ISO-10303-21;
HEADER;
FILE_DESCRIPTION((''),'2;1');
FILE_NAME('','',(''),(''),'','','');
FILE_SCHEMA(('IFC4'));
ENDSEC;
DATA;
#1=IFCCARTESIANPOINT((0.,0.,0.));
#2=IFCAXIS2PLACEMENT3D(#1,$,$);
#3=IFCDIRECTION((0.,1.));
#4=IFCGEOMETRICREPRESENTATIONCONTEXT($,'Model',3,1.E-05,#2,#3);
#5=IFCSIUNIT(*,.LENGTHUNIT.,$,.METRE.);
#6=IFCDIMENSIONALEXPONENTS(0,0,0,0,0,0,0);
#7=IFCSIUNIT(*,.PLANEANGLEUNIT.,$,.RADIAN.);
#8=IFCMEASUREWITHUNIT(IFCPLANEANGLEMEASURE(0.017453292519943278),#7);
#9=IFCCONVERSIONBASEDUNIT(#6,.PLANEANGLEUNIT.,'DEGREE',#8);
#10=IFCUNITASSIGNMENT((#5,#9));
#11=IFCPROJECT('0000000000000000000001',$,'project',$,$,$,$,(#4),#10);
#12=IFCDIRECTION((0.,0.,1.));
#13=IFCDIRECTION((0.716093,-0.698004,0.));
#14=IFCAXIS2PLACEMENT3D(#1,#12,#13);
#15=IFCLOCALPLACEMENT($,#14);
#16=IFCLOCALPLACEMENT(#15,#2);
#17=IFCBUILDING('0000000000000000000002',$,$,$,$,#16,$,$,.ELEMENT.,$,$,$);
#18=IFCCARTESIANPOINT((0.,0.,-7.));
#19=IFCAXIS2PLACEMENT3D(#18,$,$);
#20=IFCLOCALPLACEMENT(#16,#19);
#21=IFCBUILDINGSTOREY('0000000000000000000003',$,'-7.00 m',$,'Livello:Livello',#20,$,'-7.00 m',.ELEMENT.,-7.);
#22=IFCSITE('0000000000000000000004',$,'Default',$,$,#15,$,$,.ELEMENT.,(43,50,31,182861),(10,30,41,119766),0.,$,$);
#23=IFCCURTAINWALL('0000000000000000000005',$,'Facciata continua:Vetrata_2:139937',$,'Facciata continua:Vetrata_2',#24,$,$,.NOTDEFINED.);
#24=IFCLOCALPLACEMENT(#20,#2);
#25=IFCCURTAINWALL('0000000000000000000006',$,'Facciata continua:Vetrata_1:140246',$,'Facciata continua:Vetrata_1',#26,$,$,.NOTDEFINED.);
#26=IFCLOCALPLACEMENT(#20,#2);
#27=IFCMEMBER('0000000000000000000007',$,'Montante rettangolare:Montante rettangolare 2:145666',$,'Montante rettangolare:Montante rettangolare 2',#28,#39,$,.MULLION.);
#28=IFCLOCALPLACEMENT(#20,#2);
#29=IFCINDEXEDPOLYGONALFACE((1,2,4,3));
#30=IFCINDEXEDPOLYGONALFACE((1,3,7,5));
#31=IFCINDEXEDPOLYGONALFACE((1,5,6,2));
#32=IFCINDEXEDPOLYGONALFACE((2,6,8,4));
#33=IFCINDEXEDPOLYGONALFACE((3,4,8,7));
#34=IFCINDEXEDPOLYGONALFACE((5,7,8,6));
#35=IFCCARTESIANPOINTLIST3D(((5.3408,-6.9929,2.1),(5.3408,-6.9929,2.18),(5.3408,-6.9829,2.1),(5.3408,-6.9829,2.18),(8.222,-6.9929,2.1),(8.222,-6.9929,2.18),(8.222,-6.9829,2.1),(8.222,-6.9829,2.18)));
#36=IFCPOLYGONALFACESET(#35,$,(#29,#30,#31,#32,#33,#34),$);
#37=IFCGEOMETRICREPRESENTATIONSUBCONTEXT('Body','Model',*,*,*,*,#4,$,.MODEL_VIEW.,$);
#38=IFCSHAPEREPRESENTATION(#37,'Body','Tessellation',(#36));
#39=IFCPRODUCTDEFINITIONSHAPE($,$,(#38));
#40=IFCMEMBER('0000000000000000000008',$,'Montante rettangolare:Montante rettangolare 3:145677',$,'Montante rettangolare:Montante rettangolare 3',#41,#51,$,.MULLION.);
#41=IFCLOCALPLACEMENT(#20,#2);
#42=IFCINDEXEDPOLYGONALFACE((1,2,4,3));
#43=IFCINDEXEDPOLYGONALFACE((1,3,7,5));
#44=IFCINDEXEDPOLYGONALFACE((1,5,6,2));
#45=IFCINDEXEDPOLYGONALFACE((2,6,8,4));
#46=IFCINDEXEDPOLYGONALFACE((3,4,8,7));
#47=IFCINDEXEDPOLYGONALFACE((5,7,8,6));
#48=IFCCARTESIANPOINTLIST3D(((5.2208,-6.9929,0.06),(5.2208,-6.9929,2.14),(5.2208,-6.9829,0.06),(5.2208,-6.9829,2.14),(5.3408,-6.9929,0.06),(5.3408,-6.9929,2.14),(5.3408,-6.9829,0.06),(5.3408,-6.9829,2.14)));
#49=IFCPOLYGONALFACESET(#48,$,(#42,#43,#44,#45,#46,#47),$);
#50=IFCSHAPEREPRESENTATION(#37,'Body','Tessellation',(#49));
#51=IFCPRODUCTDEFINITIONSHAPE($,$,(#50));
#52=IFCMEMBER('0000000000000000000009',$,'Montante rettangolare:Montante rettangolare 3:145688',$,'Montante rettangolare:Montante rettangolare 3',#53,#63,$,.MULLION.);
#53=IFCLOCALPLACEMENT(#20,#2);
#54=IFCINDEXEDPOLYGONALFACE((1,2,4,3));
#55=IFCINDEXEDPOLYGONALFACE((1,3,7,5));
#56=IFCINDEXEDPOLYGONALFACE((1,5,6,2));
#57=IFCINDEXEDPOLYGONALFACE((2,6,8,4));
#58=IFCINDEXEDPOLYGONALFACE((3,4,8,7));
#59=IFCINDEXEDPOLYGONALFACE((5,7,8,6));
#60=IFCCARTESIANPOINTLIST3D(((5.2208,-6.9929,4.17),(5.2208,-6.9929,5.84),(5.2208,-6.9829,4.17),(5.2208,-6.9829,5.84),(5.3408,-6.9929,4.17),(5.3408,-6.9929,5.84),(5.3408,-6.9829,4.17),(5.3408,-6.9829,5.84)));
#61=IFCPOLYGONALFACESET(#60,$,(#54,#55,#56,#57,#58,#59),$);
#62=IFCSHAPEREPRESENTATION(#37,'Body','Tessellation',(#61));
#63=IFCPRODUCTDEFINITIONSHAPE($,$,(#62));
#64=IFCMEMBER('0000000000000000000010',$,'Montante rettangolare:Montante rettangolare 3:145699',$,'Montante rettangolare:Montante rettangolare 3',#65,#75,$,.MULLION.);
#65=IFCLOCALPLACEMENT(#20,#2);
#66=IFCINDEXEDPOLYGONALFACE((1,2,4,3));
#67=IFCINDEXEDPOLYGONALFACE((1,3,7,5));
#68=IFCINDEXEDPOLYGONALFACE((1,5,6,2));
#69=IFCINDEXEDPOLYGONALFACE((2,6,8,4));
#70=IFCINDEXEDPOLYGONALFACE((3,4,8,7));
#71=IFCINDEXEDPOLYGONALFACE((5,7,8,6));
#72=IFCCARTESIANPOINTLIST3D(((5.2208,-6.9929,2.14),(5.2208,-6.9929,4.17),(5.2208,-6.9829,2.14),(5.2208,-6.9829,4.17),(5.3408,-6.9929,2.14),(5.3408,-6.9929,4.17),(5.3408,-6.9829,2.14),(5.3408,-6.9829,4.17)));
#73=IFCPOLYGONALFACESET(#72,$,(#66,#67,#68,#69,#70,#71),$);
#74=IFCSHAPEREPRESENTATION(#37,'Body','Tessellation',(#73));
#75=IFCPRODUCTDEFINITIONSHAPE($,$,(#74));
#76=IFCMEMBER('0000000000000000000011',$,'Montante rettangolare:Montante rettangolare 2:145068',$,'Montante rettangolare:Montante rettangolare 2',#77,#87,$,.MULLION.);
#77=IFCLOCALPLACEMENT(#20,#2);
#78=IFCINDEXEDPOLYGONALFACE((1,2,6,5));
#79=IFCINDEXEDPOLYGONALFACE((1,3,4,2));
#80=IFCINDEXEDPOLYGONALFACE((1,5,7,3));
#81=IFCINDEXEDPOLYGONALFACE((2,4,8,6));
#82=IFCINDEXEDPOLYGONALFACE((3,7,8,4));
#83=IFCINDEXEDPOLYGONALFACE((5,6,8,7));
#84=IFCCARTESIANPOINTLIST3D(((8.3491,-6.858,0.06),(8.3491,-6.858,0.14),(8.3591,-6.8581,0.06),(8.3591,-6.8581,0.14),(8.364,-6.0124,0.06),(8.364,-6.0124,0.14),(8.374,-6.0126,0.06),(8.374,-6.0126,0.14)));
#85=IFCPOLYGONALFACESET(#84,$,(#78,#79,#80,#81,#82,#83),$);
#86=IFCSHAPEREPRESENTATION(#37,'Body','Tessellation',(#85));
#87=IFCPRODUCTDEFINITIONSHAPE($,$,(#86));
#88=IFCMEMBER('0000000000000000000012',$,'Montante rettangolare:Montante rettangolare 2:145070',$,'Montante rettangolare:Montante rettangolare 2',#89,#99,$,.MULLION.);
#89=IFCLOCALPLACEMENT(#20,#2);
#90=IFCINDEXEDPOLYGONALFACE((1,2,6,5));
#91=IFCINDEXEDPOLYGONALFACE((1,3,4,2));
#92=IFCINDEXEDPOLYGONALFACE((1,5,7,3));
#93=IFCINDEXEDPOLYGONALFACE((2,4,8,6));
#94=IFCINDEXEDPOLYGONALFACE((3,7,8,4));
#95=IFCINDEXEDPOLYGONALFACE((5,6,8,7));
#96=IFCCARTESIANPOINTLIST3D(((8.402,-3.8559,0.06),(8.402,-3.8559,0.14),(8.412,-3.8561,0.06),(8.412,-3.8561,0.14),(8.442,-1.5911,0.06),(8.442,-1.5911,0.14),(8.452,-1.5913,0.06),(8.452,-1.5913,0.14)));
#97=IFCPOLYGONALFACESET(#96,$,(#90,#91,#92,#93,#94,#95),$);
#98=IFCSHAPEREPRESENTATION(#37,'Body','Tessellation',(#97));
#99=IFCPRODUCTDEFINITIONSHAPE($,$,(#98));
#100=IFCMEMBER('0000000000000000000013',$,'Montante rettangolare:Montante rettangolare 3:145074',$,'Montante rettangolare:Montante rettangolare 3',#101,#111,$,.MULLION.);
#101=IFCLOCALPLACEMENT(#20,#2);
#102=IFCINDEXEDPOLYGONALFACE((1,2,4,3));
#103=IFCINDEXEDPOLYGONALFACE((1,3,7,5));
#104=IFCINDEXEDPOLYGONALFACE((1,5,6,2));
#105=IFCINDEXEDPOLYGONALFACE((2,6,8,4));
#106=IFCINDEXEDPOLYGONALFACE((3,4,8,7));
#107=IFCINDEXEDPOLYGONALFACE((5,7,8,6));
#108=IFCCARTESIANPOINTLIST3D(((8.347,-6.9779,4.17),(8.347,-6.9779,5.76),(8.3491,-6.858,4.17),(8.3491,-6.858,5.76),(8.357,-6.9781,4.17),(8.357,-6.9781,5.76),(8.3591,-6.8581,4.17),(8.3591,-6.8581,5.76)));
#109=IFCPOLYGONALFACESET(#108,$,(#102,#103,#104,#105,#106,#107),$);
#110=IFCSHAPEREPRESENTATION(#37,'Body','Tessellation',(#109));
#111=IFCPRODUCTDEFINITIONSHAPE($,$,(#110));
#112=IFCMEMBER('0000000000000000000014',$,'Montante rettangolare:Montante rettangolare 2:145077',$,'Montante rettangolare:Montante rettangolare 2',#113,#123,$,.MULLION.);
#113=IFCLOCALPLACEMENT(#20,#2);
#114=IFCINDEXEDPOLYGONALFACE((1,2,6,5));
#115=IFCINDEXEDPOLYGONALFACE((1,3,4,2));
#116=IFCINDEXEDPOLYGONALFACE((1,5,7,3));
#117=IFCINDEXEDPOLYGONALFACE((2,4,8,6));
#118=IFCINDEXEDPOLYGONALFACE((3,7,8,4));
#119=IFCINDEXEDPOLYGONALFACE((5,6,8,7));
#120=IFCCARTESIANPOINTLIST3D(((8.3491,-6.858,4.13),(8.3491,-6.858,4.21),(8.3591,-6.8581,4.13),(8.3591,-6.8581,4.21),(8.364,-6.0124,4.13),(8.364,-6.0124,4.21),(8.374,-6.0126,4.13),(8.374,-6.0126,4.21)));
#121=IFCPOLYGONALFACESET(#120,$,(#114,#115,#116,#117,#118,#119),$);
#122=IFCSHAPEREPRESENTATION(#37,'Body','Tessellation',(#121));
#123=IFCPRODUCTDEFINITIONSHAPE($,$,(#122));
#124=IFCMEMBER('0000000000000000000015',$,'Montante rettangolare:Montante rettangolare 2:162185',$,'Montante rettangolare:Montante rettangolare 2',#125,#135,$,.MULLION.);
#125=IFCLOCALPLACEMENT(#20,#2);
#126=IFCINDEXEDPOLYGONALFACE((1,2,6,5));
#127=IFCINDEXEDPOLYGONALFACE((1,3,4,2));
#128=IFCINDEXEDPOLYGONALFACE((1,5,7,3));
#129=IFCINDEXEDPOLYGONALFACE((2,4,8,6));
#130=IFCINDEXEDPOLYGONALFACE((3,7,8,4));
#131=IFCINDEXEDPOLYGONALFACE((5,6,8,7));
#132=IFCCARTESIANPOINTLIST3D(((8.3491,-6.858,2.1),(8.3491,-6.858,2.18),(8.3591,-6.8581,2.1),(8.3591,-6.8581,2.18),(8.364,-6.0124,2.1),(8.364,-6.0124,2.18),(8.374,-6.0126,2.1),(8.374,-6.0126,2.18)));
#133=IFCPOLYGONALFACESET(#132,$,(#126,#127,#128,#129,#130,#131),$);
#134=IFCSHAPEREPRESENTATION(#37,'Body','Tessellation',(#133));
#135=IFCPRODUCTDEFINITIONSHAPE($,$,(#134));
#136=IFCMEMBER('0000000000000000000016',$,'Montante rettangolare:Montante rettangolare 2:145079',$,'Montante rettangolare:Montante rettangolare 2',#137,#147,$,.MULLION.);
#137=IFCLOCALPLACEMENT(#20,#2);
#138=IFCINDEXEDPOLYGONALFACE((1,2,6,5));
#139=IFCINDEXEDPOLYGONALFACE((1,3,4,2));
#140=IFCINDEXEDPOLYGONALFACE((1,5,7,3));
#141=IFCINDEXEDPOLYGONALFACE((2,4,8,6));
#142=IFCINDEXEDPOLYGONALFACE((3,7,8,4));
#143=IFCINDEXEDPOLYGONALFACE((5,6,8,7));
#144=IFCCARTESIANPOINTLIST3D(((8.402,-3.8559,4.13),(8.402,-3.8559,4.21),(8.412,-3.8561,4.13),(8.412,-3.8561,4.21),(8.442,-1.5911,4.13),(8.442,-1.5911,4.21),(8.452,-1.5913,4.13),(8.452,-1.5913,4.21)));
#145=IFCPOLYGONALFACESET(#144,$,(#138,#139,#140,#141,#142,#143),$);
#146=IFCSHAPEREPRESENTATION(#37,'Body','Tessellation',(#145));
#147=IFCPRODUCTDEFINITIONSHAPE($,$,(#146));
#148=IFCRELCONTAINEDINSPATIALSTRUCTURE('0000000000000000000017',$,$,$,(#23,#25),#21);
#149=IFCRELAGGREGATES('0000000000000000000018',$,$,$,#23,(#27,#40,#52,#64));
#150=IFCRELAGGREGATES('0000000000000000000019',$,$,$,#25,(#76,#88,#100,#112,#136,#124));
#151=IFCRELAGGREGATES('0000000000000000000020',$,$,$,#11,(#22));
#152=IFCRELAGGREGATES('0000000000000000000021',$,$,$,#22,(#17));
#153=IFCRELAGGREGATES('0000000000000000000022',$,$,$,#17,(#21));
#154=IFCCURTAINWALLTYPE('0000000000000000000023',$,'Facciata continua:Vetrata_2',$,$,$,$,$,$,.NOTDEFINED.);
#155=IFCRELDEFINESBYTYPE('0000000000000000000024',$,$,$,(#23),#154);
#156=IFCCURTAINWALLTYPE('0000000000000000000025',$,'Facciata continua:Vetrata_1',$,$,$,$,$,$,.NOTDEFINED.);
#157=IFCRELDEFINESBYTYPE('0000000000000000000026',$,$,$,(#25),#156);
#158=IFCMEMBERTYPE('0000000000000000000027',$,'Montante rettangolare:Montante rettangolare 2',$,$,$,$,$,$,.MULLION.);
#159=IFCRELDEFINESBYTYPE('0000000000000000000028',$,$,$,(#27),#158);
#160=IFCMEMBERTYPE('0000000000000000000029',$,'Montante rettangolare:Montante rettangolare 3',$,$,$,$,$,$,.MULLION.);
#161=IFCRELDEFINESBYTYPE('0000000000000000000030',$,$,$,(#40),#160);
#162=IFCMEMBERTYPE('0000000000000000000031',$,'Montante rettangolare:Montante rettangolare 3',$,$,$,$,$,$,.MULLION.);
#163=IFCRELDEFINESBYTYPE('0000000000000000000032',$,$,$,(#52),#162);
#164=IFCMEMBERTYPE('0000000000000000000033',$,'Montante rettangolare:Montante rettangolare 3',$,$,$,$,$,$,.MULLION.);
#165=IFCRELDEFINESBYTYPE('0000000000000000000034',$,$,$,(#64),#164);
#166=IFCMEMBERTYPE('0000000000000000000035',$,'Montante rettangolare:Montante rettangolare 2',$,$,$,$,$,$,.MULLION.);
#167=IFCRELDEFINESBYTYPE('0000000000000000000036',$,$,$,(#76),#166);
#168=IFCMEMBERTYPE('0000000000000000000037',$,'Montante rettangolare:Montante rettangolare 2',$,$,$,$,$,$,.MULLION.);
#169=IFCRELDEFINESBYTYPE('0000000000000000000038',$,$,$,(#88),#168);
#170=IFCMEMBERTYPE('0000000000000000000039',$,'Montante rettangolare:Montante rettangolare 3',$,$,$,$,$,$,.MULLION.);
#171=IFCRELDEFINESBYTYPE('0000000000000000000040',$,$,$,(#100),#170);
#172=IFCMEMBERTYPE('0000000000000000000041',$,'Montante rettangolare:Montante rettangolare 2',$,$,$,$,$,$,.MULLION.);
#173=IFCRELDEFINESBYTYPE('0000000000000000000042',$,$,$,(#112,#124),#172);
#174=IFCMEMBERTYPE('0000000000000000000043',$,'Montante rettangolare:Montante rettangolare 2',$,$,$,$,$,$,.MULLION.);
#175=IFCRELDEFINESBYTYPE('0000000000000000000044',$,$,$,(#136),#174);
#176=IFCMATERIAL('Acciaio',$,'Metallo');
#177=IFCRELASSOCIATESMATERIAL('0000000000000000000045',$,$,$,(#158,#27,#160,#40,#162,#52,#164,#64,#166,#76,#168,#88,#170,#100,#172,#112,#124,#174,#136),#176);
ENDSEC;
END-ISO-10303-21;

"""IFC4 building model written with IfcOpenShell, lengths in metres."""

from ifc_helpers import new_model, entity, si_unit, converted_unit, direction, frame, origin, place, context, subcontext, project, spatial, indexed_curve, outline, extrude, source, transform, mapped, material, type_object, type_shapes, element, aggregate, save


model = new_model("IFC4")

# Units and contexts
model_context = context("Model", 3, precision=1e-05, world=origin(), true_north=direction((0.0, 1.0)))
body_context = subcontext(model_context, "Body", "Model", "MODEL_VIEW")
ifc_project = project(units=[si_unit("LENGTHUNIT", "METRE"), converted_unit("PLANEANGLEUNIT", "DEGREE", entity("IfcPlaneAngleMeasure", 0.017453292519943278), si_unit("PLANEANGLEUNIT", "RADIAN"), dimensions=[0, 0, 0, 0, 0, 0, 0])], contexts=[model_context])

# Site, building, storey
site_placement = place(None, frame((0.0, 0.0, 0.0), z_axis=(0.0, 0.0, 1.0), x_axis=(0.716093, -0.698004, 0.0)))
site = spatial("IfcSite", under=ifc_project, at=site_placement, Name="Default", CompositionType="ELEMENT", RefLatitude=(43, 50, 31, 182861), RefLongitude=(10, 30, 41, 119766), RefElevation=0.0)
building_placement = place(site_placement, origin())
building = spatial("IfcBuilding", under=site, at=building_placement, CompositionType="ELEMENT")
storey_placement = place(building_placement, frame((0.0, 0.0, -7.0)))
storey = spatial("IfcBuildingStorey", under=building, at=storey_placement, Name="-7.00 m", ObjectType="Livello:Livello", LongName="-7.00 m", CompositionType="ELEMENT", Elevation=-7.0)

# Curtain wall
curtain_wall_type_1 = type_object("IfcCurtainWallType", Name="Facciata continua:Vetrata_2", PredefinedType="NOTDEFINED")
curtain_wall_1_placement = place(storey_placement, frame((0.0, 0.0, 7.0)))
curtain_wall_1 = element("IfcCurtainWall", 1, at=curtain_wall_1_placement, inside=storey, type_object=curtain_wall_type_1, Name="Facciata continua:Vetrata_2:139937", ObjectType="Facciata continua:Vetrata_2", PredefinedType="NOTDEFINED")
ifc_material_1 = material(Name="Acciaio", Category="Metallo")

# Curtain wall
curtain_wall_type_2 = type_object("IfcCurtainWallType", Name="Facciata continua:Vetrata_1", PredefinedType="NOTDEFINED")
curtain_wall_2_placement = place(storey_placement, frame((0.0, 0.0, 7.0)))
curtain_wall_2 = element("IfcCurtainWall", 2, at=curtain_wall_2_placement, inside=storey, type_object=curtain_wall_type_2, Name="Facciata continua:Vetrata_1:140246", ObjectType="Facciata continua:Vetrata_1", PredefinedType="NOTDEFINED")

# Members
member_type_1 = type_object("IfcMemberType", Name="Montante rettangolare:Montante rettangolare 2", PredefinedType="MULLION", material=ifc_material_1)
shared_shape_1 = source(origin(), body_context, "Body", "SweptSolid", [
    extrude(outline(indexed_curve([(-0.04, -0.005), (0.04, -0.005), (0.04, 0.005), (-0.04, 0.005), (-0.04, -0.005)], self_intersect=False)), frame((0.0, 0.01, -2.8812), z_axis=(0.0, 0.0, 1.0), x_axis=(-1.0, 0.0, 0.0)), (0.0, 0.0, 1.0), 2.8812),
])
type_shapes(member_type_1, [shared_shape_1])
member_1_placement = place(curtain_wall_1_placement, frame((8.222, -6.9779, -4.86), z_axis=(1.0, 0.0, 0.0), x_axis=(0.0, 0.0, 1.0)))
member_1 = element("IfcMember", 3, at=member_1_placement, type_object=member_type_1, material=ifc_material_1, Name="Montante rettangolare:Montante rettangolare 2:145666", ObjectType="Montante rettangolare:Montante rettangolare 2", PredefinedType="MULLION", context=body_context, shape_type="MappedRepresentation", body=[
    mapped(shared_shape_1, transform((0.0, 0.0, 0.0), scale=1.0)),
])
member_type_2 = type_object("IfcMemberType", Name="Montante rettangolare:Montante rettangolare 3", PredefinedType="MULLION", material=ifc_material_1)
shared_shape_2 = source(origin(), body_context, "Body", "SweptSolid", [
    extrude(outline(indexed_curve([(-0.06, -0.005), (0.06, -0.005), (0.06, 0.005), (-0.06, 0.005), (-0.06, -0.005)], self_intersect=False)), frame((0.0, 0.01, -2.08), z_axis=(0.0, 0.0, 1.0), x_axis=(-1.0, 0.0, 0.0)), (0.0, 0.0, 1.0), 2.08),
])
type_shapes(member_type_2, [shared_shape_2])
member_2_placement = place(curtain_wall_1_placement, frame((5.2808, -6.9779, -6.94), z_axis=(0.0, 0.0, -1.0), x_axis=(1.0, 0.0, 0.0)))
member_2 = element("IfcMember", 4, at=member_2_placement, type_object=member_type_2, material=ifc_material_1, Name="Montante rettangolare:Montante rettangolare 3:145677", ObjectType="Montante rettangolare:Montante rettangolare 3", PredefinedType="MULLION", context=body_context, shape_type="MappedRepresentation", body=[
    mapped(shared_shape_2, transform((0.0, 0.0, 0.0), scale=1.0)),
])
member_type_3 = type_object("IfcMemberType", Name="Montante rettangolare:Montante rettangolare 3", PredefinedType="MULLION", material=ifc_material_1)
shared_shape_3 = source(origin(), body_context, "Body", "SweptSolid", [
    extrude(outline(indexed_curve([(-0.06, -0.005), (0.06, -0.005), (0.06, 0.005), (-0.06, 0.005), (-0.06, -0.005)], self_intersect=False)), frame((0.0, 0.01, -1.67), z_axis=(0.0, 0.0, 1.0), x_axis=(-1.0, 0.0, 0.0)), (0.0, 0.0, 1.0), 1.67),
])
type_shapes(member_type_3, [shared_shape_3])
member_3_placement = place(curtain_wall_1_placement, frame((5.2808, -6.9779, -2.83), z_axis=(0.0, 0.0, -1.0), x_axis=(1.0, 0.0, 0.0)))
member_3 = element("IfcMember", 5, at=member_3_placement, type_object=member_type_3, material=ifc_material_1, Name="Montante rettangolare:Montante rettangolare 3:145688", ObjectType="Montante rettangolare:Montante rettangolare 3", PredefinedType="MULLION", context=body_context, shape_type="MappedRepresentation", body=[
    mapped(shared_shape_3, transform((0.0, 0.0, 0.0), scale=1.0)),
])
member_type_4 = type_object("IfcMemberType", Name="Montante rettangolare:Montante rettangolare 3", PredefinedType="MULLION", material=ifc_material_1)
shared_shape_4 = source(origin(), body_context, "Body", "SweptSolid", [
    extrude(outline(indexed_curve([(-0.06, -0.005), (0.06, -0.005), (0.06, 0.005), (-0.06, 0.005), (-0.06, -0.005)], self_intersect=False)), frame((0.0, 0.01, -2.03), z_axis=(0.0, 0.0, 1.0), x_axis=(-1.0, 0.0, 0.0)), (0.0, 0.0, 1.0), 2.03),
])
type_shapes(member_type_4, [shared_shape_4])
member_4_placement = place(curtain_wall_1_placement, frame((5.2808, -6.9779, -4.86), z_axis=(0.0, 0.0, -1.0), x_axis=(1.0, 0.0, 0.0)))
member_4 = element("IfcMember", 6, at=member_4_placement, type_object=member_type_4, material=ifc_material_1, Name="Montante rettangolare:Montante rettangolare 3:145699", ObjectType="Montante rettangolare:Montante rettangolare 3", PredefinedType="MULLION", context=body_context, shape_type="MappedRepresentation", body=[
    mapped(shared_shape_4, transform((0.0, 0.0, 0.0), scale=1.0)),
])
aggregate(curtain_wall_1, [member_1, member_2, member_3, member_4])
member_type_5 = type_object("IfcMemberType", Name="Montante rettangolare:Montante rettangolare 2", PredefinedType="MULLION", material=ifc_material_1)
shared_shape_5 = source(origin(), body_context, "Body", "SweptSolid", [
    extrude(outline(indexed_curve([(-0.04, -0.005), (0.04, -0.005), (0.04, 0.005), (-0.04, 0.005), (-0.04, -0.005)], self_intersect=False)), frame((-0.04, 0.01, -0.8457), z_axis=(0.0, 0.0, 1.0), x_axis=(-1.0, 0.0, 0.0)), (0.0, 0.0, 1.0), 0.8457),
])
type_shapes(member_type_5, [shared_shape_5])
member_5_placement = place(curtain_wall_2_placement, frame((8.3441, -6.8579, -6.94), z_axis=(-0.017636, -0.999844, 0.0), x_axis=(0.0, 0.0, -1.0)))
member_5 = element("IfcMember", 7, at=member_5_placement, type_object=member_type_5, material=ifc_material_1, Name="Montante rettangolare:Montante rettangolare 2:145068", ObjectType="Montante rettangolare:Montante rettangolare 2", PredefinedType="MULLION", context=body_context, shape_type="MappedRepresentation", body=[
    mapped(shared_shape_5, transform((0.0, 0.0, 0.0), scale=1.0)),
])
member_type_6 = type_object("IfcMemberType", Name="Montante rettangolare:Montante rettangolare 2", PredefinedType="MULLION", material=ifc_material_1)
shared_shape_6 = source(origin(), body_context, "Body", "SweptSolid", [
    extrude(outline(indexed_curve([(-0.04, -0.005), (0.04, -0.005), (0.04, 0.005), (-0.04, 0.005), (-0.04, -0.005)], self_intersect=False)), frame((-0.04, 0.01, -2.2652), z_axis=(0.0, 0.0, 1.0), x_axis=(-1.0, 0.0, 0.0)), (0.0, 0.0, 1.0), 2.2652),
])
type_shapes(member_type_6, [shared_shape_6])
member_6_placement = place(curtain_wall_2_placement, frame((8.397, -3.8558, -6.94), z_axis=(-0.017636, -0.999844, 0.0), x_axis=(0.0, 0.0, -1.0)))
member_6 = element("IfcMember", 8, at=member_6_placement, type_object=member_type_6, material=ifc_material_1, Name="Montante rettangolare:Montante rettangolare 2:145070", ObjectType="Montante rettangolare:Montante rettangolare 2", PredefinedType="MULLION", context=body_context, shape_type="MappedRepresentation", body=[
    mapped(shared_shape_6, transform((0.0, 0.0, 0.0), scale=1.0)),
])
member_type_7 = type_object("IfcMemberType", Name="Montante rettangolare:Montante rettangolare 3", PredefinedType="MULLION", material=ifc_material_1)
shared_shape_7 = source(origin(), body_context, "Body", "SweptSolid", [
    extrude(outline(indexed_curve([(-0.06, -0.005), (0.06, -0.005), (0.06, 0.005), (-0.06, 0.005), (-0.06, -0.005)], self_intersect=False)), frame((-0.06, 0.01, -1.59), z_axis=(0.0, 0.0, 1.0), x_axis=(-1.0, 0.0, 0.0)), (0.0, 0.0, 1.0), 1.59),
])
type_shapes(member_type_7, [shared_shape_7])
member_7_placement = place(curtain_wall_2_placement, frame((8.342, -6.9779, -1.24), z_axis=(0.0, 0.0, 1.0), x_axis=(-0.017636, -0.999844, 0.0)))
member_7 = element("IfcMember", 9, at=member_7_placement, type_object=member_type_7, material=ifc_material_1, Name="Montante rettangolare:Montante rettangolare 3:145074", ObjectType="Montante rettangolare:Montante rettangolare 3", PredefinedType="MULLION", context=body_context, shape_type="MappedRepresentation", body=[
    mapped(shared_shape_7, transform((0.0, 0.0, 0.0), scale=1.0)),
])
member_type_8 = type_object("IfcMemberType", Name="Montante rettangolare:Montante rettangolare 2", PredefinedType="MULLION", material=ifc_material_1)
shared_shape_8 = source(origin(), body_context, "Body", "SweptSolid", [
    extrude(outline(indexed_curve([(-0.04, -0.005), (0.04, -0.005), (0.04, 0.005), (-0.04, 0.005), (-0.04, -0.005)], self_intersect=False)), frame((0.0, 0.01, -0.8457), z_axis=(0.0, 0.0, 1.0), x_axis=(-1.0, 0.0, 0.0)), (0.0, 0.0, 1.0), 0.8457),
])
type_shapes(member_type_8, [shared_shape_8])
member_8_placement = place(curtain_wall_2_placement, frame((8.359, -6.0123, -2.83), z_axis=(0.017636, 0.999844, 0.0), x_axis=(0.0, 0.0, 1.0)))
member_8 = element("IfcMember", 10, at=member_8_placement, type_object=member_type_8, material=ifc_material_1, Name="Montante rettangolare:Montante rettangolare 2:145077", ObjectType="Montante rettangolare:Montante rettangolare 2", PredefinedType="MULLION", context=body_context, shape_type="MappedRepresentation", body=[
    mapped(shared_shape_8, transform((0.0, 0.0, 0.0), scale=1.0)),
])
member_9_placement = place(curtain_wall_2_placement, frame((8.359, -6.0123, -4.86), z_axis=(0.017636, 0.999844, 0.0), x_axis=(0.0, 0.0, 1.0)))
member_9 = element("IfcMember", 11, at=member_9_placement, type_object=member_type_8, material=ifc_material_1, Name="Montante rettangolare:Montante rettangolare 2:162185", ObjectType="Montante rettangolare:Montante rettangolare 2", PredefinedType="MULLION", context=body_context, shape_type="MappedRepresentation", body=[
    mapped(shared_shape_8, transform((0.0, 0.0, 0.0), scale=1.0)),
])
member_type_9 = type_object("IfcMemberType", Name="Montante rettangolare:Montante rettangolare 2", PredefinedType="MULLION", material=ifc_material_1)
shared_shape_9 = source(origin(), body_context, "Body", "SweptSolid", [
    extrude(outline(indexed_curve([(-0.04, -0.005), (0.04, -0.005), (0.04, 0.005), (-0.04, 0.005), (-0.04, -0.005)], self_intersect=False)), frame((0.0, 0.01, -2.2652), z_axis=(0.0, 0.0, 1.0), x_axis=(-1.0, 0.0, 0.0)), (0.0, 0.0, 1.0), 2.2652),
])
type_shapes(member_type_9, [shared_shape_9])
member_10_placement = place(curtain_wall_2_placement, frame((8.437, -1.591, -2.83), z_axis=(0.017636, 0.999844, 0.0), x_axis=(0.0, 0.0, 1.0)))
member_10 = element("IfcMember", 12, at=member_10_placement, type_object=member_type_9, material=ifc_material_1, Name="Montante rettangolare:Montante rettangolare 2:145079", ObjectType="Montante rettangolare:Montante rettangolare 2", PredefinedType="MULLION", context=body_context, shape_type="MappedRepresentation", body=[
    mapped(shared_shape_9, transform((0.0, 0.0, 0.0), scale=1.0)),
])

aggregate(curtain_wall_2, [member_5, member_6, member_7, member_8, member_10, member_9])

save(model, "model.ifc")
